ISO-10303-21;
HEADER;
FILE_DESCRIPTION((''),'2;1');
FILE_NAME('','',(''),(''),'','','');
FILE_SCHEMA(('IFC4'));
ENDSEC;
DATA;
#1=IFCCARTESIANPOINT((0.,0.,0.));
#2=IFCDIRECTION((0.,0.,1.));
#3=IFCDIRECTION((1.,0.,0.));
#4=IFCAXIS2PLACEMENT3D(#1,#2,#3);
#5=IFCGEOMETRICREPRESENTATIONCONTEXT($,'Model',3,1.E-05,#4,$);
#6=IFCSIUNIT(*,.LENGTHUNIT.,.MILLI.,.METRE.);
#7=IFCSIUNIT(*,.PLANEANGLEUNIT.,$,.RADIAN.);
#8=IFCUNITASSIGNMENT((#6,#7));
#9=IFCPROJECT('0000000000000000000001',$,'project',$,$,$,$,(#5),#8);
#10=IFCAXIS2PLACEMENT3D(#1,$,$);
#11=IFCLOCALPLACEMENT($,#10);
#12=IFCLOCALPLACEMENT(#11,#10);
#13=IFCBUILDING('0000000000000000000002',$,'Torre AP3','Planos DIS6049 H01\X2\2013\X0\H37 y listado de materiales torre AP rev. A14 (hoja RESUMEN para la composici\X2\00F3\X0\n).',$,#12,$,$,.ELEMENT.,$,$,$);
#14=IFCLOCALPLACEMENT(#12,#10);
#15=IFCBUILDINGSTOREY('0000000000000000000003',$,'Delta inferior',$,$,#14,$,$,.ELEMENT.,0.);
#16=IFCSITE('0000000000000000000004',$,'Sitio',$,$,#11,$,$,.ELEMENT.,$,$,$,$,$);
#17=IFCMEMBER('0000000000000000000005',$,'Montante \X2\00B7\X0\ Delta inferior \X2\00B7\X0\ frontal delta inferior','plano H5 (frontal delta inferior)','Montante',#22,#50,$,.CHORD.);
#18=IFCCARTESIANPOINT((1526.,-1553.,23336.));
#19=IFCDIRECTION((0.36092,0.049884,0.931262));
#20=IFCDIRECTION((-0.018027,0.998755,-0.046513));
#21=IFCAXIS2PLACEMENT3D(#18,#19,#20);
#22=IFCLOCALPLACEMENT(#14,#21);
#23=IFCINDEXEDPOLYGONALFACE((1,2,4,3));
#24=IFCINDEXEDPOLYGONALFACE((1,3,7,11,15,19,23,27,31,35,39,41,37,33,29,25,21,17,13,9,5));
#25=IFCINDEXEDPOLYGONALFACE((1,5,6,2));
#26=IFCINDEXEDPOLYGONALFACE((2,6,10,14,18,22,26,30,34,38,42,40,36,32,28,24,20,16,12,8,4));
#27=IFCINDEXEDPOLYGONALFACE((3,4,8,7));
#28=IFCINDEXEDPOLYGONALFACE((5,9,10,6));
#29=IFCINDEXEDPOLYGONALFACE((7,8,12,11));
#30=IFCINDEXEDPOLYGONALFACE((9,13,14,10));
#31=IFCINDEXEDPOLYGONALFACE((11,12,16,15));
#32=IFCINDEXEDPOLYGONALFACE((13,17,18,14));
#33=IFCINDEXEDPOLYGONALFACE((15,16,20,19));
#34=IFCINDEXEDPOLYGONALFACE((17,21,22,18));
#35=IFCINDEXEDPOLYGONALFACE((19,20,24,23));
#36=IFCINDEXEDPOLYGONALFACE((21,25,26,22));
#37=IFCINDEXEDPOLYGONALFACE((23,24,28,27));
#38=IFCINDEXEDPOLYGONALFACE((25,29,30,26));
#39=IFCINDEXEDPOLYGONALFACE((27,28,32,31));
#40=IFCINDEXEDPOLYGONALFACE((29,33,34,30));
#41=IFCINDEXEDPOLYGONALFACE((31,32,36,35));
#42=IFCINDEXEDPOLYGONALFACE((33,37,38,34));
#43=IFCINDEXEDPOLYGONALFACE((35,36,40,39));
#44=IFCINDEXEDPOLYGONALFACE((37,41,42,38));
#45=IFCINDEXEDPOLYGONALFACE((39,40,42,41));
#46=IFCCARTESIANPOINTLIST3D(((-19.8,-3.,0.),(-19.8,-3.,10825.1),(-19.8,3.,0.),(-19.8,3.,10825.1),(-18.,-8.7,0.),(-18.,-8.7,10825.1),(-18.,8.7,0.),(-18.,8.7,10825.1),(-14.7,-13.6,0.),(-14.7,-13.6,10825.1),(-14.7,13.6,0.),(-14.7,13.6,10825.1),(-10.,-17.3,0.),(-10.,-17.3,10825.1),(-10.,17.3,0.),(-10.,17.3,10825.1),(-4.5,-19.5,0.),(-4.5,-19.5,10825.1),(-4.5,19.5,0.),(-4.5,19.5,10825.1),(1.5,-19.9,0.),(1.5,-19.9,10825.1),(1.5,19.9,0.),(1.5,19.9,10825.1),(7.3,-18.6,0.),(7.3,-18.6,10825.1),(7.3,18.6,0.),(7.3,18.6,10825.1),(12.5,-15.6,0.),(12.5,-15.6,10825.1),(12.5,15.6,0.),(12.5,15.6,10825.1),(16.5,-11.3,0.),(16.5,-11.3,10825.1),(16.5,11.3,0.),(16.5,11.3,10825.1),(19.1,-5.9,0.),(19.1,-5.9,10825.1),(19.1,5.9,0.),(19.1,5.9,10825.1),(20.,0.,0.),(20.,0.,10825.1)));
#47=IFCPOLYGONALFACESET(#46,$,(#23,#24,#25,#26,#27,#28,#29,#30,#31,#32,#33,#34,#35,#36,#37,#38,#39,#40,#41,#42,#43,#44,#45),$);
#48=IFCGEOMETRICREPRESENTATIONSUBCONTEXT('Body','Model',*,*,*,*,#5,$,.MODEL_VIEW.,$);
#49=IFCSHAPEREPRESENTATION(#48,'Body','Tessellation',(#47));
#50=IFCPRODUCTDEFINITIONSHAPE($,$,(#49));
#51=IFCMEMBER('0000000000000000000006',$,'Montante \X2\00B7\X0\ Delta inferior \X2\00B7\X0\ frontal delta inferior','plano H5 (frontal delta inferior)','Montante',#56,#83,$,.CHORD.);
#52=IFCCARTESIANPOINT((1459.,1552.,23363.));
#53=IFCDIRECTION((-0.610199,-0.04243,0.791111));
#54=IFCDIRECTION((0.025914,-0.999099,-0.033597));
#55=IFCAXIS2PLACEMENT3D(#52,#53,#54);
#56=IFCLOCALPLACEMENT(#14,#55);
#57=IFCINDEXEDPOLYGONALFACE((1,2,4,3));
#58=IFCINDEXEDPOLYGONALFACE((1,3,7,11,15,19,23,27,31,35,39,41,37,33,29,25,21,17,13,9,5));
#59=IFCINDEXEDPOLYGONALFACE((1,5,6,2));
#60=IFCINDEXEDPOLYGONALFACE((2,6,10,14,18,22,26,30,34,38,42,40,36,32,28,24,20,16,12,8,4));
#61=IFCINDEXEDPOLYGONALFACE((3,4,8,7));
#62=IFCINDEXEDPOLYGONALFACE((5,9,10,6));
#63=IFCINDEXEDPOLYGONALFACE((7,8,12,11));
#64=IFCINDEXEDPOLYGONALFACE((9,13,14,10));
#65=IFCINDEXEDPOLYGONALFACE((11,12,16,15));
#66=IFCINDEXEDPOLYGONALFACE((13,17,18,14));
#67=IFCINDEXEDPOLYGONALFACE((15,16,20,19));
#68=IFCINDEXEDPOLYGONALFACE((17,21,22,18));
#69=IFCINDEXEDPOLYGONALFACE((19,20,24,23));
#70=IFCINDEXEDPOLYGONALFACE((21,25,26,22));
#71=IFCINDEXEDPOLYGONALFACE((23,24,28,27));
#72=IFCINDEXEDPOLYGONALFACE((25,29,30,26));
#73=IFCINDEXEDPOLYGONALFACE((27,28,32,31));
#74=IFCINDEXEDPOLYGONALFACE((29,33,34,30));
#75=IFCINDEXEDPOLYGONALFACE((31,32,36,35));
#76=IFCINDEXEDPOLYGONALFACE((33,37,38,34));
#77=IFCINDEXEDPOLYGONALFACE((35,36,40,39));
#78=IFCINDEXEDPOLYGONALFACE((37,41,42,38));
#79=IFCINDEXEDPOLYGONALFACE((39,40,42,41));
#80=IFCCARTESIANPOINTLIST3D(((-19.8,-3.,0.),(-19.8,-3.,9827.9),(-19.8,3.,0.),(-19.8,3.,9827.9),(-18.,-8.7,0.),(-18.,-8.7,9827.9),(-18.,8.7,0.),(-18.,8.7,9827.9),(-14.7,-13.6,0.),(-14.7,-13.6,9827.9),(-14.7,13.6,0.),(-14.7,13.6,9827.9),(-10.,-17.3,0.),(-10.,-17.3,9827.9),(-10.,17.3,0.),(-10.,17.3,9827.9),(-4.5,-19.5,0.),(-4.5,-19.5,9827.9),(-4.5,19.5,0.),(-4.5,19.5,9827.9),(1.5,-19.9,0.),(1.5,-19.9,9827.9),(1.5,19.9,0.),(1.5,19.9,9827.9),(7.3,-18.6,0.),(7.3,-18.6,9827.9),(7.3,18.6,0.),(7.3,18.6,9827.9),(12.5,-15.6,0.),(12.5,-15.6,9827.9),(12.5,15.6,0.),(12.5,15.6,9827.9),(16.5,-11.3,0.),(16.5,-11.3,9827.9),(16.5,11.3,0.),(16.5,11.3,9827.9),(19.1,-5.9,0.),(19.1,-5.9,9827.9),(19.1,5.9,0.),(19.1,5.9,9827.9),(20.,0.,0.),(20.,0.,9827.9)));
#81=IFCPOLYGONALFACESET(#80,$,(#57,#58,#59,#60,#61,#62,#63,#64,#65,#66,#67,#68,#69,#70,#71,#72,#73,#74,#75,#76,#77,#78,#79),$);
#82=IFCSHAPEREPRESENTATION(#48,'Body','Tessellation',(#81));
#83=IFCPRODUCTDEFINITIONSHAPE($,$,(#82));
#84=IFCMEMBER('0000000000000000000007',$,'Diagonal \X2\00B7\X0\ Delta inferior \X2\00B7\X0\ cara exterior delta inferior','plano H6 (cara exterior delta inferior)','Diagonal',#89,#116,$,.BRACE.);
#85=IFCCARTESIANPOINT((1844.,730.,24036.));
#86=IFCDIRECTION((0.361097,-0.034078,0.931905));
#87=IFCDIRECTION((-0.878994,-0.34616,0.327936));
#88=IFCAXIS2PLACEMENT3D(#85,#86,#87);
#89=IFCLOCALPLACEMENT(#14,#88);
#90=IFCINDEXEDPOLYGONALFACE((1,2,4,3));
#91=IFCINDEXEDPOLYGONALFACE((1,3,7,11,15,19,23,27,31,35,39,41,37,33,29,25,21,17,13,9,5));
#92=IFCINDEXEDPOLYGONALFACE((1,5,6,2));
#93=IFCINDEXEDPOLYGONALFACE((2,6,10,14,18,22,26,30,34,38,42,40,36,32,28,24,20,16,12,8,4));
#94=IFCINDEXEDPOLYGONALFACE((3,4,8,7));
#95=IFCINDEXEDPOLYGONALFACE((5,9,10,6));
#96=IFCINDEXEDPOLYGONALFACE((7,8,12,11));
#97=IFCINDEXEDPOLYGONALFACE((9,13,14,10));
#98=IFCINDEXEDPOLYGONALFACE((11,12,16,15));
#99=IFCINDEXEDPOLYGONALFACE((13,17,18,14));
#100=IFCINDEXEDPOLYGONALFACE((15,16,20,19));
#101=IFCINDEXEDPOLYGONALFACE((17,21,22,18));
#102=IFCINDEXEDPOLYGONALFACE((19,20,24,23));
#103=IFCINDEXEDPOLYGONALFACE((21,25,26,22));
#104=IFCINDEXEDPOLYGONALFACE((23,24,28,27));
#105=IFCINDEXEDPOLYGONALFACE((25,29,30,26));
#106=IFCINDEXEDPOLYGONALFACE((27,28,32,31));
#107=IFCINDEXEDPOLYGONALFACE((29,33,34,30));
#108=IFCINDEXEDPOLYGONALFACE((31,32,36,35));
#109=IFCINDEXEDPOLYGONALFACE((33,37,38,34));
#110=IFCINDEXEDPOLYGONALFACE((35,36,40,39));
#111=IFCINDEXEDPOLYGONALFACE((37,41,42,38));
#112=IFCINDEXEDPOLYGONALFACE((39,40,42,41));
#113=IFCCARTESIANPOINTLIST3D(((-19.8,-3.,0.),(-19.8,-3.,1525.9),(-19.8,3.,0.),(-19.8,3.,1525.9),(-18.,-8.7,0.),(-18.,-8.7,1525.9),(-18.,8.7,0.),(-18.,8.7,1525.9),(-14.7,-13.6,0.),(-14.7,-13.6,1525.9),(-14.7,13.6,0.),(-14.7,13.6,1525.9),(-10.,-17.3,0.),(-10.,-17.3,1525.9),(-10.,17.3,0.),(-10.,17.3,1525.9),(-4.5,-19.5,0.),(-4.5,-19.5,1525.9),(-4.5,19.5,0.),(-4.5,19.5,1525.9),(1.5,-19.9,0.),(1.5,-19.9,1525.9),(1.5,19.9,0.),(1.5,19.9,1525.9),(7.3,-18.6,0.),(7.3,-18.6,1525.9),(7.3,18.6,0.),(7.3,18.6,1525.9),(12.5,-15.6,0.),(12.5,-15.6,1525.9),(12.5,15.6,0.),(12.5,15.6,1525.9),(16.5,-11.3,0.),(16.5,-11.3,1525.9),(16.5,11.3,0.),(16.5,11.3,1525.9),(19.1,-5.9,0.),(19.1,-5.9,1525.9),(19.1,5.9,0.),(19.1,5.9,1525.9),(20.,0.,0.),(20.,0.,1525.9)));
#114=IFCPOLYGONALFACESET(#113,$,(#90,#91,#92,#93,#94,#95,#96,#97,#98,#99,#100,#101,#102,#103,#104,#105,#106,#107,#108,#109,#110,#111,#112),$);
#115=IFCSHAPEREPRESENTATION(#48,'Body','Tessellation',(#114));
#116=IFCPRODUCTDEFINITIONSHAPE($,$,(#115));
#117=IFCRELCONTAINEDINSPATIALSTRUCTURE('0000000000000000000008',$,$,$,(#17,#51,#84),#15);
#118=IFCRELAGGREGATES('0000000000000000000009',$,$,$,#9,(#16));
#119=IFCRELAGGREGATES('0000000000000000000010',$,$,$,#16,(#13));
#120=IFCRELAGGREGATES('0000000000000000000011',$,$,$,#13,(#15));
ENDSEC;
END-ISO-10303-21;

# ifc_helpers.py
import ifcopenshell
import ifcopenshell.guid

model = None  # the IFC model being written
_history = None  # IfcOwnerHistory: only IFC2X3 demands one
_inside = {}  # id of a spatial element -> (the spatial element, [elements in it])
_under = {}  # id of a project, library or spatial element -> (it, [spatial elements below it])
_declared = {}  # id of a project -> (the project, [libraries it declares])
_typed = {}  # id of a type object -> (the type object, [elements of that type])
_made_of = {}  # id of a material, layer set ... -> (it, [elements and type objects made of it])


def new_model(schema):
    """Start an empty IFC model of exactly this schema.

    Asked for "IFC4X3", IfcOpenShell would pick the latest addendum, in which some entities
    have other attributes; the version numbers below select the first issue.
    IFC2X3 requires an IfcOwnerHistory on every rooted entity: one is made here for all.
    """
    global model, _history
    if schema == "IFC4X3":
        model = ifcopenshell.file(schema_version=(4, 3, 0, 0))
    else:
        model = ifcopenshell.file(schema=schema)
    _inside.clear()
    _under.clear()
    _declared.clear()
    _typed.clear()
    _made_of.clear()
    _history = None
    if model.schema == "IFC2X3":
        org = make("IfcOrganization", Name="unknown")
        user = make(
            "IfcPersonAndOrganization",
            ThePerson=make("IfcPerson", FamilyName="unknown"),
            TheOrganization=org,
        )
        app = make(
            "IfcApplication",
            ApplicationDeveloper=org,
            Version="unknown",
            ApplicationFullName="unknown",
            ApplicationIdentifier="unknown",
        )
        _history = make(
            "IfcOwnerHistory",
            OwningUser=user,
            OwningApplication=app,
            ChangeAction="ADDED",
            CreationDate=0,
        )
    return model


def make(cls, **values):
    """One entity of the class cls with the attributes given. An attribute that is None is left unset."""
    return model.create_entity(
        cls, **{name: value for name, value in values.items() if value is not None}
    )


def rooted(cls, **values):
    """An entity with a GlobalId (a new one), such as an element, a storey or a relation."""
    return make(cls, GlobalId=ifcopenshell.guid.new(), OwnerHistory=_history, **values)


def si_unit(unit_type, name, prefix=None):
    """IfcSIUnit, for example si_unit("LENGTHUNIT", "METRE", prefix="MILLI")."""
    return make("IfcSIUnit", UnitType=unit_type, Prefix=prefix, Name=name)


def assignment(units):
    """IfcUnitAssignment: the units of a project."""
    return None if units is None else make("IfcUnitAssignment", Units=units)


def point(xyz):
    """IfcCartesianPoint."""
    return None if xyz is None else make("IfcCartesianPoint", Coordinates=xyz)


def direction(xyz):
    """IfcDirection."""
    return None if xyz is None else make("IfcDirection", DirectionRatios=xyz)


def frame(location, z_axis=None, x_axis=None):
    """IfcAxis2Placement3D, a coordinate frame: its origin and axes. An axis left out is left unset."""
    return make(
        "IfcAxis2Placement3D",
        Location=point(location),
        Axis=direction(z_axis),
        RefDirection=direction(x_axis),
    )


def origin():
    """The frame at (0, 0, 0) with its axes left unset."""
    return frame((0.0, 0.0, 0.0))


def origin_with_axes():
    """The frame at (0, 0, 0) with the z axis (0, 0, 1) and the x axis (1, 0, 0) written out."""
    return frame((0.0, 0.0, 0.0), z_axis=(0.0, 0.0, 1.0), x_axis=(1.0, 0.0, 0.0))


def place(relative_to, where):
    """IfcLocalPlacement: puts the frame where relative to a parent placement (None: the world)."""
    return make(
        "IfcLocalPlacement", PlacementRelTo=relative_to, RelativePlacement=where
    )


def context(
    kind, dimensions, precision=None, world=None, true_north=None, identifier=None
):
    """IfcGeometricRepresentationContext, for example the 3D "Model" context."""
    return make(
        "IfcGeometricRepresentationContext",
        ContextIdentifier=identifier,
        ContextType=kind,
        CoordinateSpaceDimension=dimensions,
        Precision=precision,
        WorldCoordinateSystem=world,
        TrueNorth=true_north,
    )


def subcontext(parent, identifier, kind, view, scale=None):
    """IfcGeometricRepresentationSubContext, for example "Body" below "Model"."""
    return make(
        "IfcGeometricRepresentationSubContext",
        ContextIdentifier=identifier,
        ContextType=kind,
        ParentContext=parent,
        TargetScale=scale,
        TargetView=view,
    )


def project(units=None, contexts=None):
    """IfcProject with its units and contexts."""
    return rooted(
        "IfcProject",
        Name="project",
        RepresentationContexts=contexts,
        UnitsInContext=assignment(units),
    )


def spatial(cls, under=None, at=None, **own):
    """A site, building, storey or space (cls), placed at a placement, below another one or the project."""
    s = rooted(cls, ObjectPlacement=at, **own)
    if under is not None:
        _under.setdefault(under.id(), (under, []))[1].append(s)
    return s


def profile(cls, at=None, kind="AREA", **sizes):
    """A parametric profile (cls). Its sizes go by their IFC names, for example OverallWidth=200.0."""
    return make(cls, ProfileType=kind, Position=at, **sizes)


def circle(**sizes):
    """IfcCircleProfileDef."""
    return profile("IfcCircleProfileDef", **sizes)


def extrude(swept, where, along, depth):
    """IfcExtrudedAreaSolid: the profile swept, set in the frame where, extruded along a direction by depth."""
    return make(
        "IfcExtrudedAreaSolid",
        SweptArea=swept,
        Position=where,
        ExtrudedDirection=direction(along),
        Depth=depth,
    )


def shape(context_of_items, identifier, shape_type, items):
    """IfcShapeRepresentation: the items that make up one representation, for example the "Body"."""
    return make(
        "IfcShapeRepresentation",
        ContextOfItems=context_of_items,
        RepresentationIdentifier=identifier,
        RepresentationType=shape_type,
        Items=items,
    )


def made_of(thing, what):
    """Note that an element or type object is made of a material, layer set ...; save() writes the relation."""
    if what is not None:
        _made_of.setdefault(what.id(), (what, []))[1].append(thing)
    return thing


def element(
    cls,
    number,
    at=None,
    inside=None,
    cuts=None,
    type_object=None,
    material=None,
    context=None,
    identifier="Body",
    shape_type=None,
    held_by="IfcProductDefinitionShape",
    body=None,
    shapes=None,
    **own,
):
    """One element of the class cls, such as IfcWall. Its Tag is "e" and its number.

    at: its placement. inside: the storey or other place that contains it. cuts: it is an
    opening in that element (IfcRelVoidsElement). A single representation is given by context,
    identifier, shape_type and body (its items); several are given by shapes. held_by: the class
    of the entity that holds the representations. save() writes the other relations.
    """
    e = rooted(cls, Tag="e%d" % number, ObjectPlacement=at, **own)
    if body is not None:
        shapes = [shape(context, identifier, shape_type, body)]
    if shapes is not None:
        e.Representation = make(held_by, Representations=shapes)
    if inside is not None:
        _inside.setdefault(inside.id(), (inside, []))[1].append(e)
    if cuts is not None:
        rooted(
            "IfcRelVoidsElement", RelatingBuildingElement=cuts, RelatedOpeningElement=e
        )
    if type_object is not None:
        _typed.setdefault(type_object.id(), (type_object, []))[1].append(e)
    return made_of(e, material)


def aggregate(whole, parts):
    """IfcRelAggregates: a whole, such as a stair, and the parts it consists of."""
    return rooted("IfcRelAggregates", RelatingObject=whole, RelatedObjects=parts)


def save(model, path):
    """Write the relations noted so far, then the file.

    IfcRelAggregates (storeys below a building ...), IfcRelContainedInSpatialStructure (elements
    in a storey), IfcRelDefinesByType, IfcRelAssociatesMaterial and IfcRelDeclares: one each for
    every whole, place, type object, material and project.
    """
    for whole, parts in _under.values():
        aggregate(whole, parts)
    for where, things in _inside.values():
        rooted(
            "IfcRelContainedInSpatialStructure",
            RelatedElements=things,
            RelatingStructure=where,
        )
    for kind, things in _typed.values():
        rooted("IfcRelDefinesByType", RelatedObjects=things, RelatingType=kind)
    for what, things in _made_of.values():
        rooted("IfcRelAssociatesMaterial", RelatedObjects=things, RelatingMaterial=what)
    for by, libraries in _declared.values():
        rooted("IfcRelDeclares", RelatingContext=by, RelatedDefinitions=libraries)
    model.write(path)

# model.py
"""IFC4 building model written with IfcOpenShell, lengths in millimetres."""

from ifc_helpers import new_model, si_unit, frame, origin, origin_with_axes, place, context, subcontext, project, spatial, circle, extrude, element, save


model = new_model("IFC4")

# Units and contexts
model_context = context("Model", 3, precision=1e-05, world=origin_with_axes())
body_context = subcontext(model_context, "Body", "Model", "MODEL_VIEW")
ifc_project = project(units=[si_unit("LENGTHUNIT", "METRE", prefix="MILLI"), si_unit("PLANEANGLEUNIT", "RADIAN")], contexts=[model_context])

# Site, building, storey
site_placement = place(None, origin())
site = spatial("IfcSite", under=ifc_project, at=site_placement, Name="Sitio", CompositionType="ELEMENT")
building_placement = place(site_placement, origin())
building = spatial("IfcBuilding", under=site, at=building_placement, Name="Torre AP3", Description="Planos DIS6049 H01–H37 y listado de materiales torre AP rev. A14 (hoja RESUMEN para la composición).", CompositionType="ELEMENT")
storey_placement = place(building_placement, origin())
storey = spatial("IfcBuildingStorey", under=building, at=storey_placement, Name="Delta inferior", CompositionType="ELEMENT", Elevation=0.0)

# Members
for number, where, z_axis, x_axis, name in (
    (1, (1526.0, -1553.0, 23336.0), (0.36092, 0.049884, 0.931262), (-0.018027, 0.998755, -0.046513), "Montante · Delta inferior · frontal delta inferior"),
):
    element("IfcMember", number, at=place(storey_placement, frame(where, z_axis=z_axis, x_axis=x_axis)), inside=storey, Name=name, Description="plano H5 (frontal delta inferior)", ObjectType="Montante", PredefinedType="CHORD", context=body_context, shape_type="SweptSolid", body=[
        extrude(circle(Radius=20.0), None, (0.0, 0.0, 1.0), 10825.1),
    ])
for number, where, z_axis, x_axis, name in (
    (2, (1459.0, 1552.0, 23363.0), (-0.610199, -0.04243, 0.791111), (0.025914, -0.999099, -0.033597), "Montante · Delta inferior · frontal delta inferior"),
):
    element("IfcMember", number, at=place(storey_placement, frame(where, z_axis=z_axis, x_axis=x_axis)), inside=storey, Name=name, Description="plano H5 (frontal delta inferior)", ObjectType="Montante", PredefinedType="CHORD", context=body_context, shape_type="SweptSolid", body=[
        extrude(circle(Radius=20.0), None, (0.0, 0.0, 1.0), 9827.9),
    ])
member_1_placement = place(storey_placement, frame((1844.0, 730.0, 24036.0), z_axis=(0.361097, -0.034078, 0.931905), x_axis=(-0.878994, -0.34616, 0.327936)))
element("IfcMember", 3, at=member_1_placement, inside=storey, Name="Diagonal · Delta inferior · cara exterior delta inferior", Description="plano H6 (cara exterior delta inferior)", ObjectType="Diagonal", PredefinedType="BRACE", context=body_context, shape_type="SweptSolid", body=[
    extrude(circle(Radius=20.0), None, (0.0, 0.0, 1.0), 1525.9),
])

save(model, "model.ifc")
